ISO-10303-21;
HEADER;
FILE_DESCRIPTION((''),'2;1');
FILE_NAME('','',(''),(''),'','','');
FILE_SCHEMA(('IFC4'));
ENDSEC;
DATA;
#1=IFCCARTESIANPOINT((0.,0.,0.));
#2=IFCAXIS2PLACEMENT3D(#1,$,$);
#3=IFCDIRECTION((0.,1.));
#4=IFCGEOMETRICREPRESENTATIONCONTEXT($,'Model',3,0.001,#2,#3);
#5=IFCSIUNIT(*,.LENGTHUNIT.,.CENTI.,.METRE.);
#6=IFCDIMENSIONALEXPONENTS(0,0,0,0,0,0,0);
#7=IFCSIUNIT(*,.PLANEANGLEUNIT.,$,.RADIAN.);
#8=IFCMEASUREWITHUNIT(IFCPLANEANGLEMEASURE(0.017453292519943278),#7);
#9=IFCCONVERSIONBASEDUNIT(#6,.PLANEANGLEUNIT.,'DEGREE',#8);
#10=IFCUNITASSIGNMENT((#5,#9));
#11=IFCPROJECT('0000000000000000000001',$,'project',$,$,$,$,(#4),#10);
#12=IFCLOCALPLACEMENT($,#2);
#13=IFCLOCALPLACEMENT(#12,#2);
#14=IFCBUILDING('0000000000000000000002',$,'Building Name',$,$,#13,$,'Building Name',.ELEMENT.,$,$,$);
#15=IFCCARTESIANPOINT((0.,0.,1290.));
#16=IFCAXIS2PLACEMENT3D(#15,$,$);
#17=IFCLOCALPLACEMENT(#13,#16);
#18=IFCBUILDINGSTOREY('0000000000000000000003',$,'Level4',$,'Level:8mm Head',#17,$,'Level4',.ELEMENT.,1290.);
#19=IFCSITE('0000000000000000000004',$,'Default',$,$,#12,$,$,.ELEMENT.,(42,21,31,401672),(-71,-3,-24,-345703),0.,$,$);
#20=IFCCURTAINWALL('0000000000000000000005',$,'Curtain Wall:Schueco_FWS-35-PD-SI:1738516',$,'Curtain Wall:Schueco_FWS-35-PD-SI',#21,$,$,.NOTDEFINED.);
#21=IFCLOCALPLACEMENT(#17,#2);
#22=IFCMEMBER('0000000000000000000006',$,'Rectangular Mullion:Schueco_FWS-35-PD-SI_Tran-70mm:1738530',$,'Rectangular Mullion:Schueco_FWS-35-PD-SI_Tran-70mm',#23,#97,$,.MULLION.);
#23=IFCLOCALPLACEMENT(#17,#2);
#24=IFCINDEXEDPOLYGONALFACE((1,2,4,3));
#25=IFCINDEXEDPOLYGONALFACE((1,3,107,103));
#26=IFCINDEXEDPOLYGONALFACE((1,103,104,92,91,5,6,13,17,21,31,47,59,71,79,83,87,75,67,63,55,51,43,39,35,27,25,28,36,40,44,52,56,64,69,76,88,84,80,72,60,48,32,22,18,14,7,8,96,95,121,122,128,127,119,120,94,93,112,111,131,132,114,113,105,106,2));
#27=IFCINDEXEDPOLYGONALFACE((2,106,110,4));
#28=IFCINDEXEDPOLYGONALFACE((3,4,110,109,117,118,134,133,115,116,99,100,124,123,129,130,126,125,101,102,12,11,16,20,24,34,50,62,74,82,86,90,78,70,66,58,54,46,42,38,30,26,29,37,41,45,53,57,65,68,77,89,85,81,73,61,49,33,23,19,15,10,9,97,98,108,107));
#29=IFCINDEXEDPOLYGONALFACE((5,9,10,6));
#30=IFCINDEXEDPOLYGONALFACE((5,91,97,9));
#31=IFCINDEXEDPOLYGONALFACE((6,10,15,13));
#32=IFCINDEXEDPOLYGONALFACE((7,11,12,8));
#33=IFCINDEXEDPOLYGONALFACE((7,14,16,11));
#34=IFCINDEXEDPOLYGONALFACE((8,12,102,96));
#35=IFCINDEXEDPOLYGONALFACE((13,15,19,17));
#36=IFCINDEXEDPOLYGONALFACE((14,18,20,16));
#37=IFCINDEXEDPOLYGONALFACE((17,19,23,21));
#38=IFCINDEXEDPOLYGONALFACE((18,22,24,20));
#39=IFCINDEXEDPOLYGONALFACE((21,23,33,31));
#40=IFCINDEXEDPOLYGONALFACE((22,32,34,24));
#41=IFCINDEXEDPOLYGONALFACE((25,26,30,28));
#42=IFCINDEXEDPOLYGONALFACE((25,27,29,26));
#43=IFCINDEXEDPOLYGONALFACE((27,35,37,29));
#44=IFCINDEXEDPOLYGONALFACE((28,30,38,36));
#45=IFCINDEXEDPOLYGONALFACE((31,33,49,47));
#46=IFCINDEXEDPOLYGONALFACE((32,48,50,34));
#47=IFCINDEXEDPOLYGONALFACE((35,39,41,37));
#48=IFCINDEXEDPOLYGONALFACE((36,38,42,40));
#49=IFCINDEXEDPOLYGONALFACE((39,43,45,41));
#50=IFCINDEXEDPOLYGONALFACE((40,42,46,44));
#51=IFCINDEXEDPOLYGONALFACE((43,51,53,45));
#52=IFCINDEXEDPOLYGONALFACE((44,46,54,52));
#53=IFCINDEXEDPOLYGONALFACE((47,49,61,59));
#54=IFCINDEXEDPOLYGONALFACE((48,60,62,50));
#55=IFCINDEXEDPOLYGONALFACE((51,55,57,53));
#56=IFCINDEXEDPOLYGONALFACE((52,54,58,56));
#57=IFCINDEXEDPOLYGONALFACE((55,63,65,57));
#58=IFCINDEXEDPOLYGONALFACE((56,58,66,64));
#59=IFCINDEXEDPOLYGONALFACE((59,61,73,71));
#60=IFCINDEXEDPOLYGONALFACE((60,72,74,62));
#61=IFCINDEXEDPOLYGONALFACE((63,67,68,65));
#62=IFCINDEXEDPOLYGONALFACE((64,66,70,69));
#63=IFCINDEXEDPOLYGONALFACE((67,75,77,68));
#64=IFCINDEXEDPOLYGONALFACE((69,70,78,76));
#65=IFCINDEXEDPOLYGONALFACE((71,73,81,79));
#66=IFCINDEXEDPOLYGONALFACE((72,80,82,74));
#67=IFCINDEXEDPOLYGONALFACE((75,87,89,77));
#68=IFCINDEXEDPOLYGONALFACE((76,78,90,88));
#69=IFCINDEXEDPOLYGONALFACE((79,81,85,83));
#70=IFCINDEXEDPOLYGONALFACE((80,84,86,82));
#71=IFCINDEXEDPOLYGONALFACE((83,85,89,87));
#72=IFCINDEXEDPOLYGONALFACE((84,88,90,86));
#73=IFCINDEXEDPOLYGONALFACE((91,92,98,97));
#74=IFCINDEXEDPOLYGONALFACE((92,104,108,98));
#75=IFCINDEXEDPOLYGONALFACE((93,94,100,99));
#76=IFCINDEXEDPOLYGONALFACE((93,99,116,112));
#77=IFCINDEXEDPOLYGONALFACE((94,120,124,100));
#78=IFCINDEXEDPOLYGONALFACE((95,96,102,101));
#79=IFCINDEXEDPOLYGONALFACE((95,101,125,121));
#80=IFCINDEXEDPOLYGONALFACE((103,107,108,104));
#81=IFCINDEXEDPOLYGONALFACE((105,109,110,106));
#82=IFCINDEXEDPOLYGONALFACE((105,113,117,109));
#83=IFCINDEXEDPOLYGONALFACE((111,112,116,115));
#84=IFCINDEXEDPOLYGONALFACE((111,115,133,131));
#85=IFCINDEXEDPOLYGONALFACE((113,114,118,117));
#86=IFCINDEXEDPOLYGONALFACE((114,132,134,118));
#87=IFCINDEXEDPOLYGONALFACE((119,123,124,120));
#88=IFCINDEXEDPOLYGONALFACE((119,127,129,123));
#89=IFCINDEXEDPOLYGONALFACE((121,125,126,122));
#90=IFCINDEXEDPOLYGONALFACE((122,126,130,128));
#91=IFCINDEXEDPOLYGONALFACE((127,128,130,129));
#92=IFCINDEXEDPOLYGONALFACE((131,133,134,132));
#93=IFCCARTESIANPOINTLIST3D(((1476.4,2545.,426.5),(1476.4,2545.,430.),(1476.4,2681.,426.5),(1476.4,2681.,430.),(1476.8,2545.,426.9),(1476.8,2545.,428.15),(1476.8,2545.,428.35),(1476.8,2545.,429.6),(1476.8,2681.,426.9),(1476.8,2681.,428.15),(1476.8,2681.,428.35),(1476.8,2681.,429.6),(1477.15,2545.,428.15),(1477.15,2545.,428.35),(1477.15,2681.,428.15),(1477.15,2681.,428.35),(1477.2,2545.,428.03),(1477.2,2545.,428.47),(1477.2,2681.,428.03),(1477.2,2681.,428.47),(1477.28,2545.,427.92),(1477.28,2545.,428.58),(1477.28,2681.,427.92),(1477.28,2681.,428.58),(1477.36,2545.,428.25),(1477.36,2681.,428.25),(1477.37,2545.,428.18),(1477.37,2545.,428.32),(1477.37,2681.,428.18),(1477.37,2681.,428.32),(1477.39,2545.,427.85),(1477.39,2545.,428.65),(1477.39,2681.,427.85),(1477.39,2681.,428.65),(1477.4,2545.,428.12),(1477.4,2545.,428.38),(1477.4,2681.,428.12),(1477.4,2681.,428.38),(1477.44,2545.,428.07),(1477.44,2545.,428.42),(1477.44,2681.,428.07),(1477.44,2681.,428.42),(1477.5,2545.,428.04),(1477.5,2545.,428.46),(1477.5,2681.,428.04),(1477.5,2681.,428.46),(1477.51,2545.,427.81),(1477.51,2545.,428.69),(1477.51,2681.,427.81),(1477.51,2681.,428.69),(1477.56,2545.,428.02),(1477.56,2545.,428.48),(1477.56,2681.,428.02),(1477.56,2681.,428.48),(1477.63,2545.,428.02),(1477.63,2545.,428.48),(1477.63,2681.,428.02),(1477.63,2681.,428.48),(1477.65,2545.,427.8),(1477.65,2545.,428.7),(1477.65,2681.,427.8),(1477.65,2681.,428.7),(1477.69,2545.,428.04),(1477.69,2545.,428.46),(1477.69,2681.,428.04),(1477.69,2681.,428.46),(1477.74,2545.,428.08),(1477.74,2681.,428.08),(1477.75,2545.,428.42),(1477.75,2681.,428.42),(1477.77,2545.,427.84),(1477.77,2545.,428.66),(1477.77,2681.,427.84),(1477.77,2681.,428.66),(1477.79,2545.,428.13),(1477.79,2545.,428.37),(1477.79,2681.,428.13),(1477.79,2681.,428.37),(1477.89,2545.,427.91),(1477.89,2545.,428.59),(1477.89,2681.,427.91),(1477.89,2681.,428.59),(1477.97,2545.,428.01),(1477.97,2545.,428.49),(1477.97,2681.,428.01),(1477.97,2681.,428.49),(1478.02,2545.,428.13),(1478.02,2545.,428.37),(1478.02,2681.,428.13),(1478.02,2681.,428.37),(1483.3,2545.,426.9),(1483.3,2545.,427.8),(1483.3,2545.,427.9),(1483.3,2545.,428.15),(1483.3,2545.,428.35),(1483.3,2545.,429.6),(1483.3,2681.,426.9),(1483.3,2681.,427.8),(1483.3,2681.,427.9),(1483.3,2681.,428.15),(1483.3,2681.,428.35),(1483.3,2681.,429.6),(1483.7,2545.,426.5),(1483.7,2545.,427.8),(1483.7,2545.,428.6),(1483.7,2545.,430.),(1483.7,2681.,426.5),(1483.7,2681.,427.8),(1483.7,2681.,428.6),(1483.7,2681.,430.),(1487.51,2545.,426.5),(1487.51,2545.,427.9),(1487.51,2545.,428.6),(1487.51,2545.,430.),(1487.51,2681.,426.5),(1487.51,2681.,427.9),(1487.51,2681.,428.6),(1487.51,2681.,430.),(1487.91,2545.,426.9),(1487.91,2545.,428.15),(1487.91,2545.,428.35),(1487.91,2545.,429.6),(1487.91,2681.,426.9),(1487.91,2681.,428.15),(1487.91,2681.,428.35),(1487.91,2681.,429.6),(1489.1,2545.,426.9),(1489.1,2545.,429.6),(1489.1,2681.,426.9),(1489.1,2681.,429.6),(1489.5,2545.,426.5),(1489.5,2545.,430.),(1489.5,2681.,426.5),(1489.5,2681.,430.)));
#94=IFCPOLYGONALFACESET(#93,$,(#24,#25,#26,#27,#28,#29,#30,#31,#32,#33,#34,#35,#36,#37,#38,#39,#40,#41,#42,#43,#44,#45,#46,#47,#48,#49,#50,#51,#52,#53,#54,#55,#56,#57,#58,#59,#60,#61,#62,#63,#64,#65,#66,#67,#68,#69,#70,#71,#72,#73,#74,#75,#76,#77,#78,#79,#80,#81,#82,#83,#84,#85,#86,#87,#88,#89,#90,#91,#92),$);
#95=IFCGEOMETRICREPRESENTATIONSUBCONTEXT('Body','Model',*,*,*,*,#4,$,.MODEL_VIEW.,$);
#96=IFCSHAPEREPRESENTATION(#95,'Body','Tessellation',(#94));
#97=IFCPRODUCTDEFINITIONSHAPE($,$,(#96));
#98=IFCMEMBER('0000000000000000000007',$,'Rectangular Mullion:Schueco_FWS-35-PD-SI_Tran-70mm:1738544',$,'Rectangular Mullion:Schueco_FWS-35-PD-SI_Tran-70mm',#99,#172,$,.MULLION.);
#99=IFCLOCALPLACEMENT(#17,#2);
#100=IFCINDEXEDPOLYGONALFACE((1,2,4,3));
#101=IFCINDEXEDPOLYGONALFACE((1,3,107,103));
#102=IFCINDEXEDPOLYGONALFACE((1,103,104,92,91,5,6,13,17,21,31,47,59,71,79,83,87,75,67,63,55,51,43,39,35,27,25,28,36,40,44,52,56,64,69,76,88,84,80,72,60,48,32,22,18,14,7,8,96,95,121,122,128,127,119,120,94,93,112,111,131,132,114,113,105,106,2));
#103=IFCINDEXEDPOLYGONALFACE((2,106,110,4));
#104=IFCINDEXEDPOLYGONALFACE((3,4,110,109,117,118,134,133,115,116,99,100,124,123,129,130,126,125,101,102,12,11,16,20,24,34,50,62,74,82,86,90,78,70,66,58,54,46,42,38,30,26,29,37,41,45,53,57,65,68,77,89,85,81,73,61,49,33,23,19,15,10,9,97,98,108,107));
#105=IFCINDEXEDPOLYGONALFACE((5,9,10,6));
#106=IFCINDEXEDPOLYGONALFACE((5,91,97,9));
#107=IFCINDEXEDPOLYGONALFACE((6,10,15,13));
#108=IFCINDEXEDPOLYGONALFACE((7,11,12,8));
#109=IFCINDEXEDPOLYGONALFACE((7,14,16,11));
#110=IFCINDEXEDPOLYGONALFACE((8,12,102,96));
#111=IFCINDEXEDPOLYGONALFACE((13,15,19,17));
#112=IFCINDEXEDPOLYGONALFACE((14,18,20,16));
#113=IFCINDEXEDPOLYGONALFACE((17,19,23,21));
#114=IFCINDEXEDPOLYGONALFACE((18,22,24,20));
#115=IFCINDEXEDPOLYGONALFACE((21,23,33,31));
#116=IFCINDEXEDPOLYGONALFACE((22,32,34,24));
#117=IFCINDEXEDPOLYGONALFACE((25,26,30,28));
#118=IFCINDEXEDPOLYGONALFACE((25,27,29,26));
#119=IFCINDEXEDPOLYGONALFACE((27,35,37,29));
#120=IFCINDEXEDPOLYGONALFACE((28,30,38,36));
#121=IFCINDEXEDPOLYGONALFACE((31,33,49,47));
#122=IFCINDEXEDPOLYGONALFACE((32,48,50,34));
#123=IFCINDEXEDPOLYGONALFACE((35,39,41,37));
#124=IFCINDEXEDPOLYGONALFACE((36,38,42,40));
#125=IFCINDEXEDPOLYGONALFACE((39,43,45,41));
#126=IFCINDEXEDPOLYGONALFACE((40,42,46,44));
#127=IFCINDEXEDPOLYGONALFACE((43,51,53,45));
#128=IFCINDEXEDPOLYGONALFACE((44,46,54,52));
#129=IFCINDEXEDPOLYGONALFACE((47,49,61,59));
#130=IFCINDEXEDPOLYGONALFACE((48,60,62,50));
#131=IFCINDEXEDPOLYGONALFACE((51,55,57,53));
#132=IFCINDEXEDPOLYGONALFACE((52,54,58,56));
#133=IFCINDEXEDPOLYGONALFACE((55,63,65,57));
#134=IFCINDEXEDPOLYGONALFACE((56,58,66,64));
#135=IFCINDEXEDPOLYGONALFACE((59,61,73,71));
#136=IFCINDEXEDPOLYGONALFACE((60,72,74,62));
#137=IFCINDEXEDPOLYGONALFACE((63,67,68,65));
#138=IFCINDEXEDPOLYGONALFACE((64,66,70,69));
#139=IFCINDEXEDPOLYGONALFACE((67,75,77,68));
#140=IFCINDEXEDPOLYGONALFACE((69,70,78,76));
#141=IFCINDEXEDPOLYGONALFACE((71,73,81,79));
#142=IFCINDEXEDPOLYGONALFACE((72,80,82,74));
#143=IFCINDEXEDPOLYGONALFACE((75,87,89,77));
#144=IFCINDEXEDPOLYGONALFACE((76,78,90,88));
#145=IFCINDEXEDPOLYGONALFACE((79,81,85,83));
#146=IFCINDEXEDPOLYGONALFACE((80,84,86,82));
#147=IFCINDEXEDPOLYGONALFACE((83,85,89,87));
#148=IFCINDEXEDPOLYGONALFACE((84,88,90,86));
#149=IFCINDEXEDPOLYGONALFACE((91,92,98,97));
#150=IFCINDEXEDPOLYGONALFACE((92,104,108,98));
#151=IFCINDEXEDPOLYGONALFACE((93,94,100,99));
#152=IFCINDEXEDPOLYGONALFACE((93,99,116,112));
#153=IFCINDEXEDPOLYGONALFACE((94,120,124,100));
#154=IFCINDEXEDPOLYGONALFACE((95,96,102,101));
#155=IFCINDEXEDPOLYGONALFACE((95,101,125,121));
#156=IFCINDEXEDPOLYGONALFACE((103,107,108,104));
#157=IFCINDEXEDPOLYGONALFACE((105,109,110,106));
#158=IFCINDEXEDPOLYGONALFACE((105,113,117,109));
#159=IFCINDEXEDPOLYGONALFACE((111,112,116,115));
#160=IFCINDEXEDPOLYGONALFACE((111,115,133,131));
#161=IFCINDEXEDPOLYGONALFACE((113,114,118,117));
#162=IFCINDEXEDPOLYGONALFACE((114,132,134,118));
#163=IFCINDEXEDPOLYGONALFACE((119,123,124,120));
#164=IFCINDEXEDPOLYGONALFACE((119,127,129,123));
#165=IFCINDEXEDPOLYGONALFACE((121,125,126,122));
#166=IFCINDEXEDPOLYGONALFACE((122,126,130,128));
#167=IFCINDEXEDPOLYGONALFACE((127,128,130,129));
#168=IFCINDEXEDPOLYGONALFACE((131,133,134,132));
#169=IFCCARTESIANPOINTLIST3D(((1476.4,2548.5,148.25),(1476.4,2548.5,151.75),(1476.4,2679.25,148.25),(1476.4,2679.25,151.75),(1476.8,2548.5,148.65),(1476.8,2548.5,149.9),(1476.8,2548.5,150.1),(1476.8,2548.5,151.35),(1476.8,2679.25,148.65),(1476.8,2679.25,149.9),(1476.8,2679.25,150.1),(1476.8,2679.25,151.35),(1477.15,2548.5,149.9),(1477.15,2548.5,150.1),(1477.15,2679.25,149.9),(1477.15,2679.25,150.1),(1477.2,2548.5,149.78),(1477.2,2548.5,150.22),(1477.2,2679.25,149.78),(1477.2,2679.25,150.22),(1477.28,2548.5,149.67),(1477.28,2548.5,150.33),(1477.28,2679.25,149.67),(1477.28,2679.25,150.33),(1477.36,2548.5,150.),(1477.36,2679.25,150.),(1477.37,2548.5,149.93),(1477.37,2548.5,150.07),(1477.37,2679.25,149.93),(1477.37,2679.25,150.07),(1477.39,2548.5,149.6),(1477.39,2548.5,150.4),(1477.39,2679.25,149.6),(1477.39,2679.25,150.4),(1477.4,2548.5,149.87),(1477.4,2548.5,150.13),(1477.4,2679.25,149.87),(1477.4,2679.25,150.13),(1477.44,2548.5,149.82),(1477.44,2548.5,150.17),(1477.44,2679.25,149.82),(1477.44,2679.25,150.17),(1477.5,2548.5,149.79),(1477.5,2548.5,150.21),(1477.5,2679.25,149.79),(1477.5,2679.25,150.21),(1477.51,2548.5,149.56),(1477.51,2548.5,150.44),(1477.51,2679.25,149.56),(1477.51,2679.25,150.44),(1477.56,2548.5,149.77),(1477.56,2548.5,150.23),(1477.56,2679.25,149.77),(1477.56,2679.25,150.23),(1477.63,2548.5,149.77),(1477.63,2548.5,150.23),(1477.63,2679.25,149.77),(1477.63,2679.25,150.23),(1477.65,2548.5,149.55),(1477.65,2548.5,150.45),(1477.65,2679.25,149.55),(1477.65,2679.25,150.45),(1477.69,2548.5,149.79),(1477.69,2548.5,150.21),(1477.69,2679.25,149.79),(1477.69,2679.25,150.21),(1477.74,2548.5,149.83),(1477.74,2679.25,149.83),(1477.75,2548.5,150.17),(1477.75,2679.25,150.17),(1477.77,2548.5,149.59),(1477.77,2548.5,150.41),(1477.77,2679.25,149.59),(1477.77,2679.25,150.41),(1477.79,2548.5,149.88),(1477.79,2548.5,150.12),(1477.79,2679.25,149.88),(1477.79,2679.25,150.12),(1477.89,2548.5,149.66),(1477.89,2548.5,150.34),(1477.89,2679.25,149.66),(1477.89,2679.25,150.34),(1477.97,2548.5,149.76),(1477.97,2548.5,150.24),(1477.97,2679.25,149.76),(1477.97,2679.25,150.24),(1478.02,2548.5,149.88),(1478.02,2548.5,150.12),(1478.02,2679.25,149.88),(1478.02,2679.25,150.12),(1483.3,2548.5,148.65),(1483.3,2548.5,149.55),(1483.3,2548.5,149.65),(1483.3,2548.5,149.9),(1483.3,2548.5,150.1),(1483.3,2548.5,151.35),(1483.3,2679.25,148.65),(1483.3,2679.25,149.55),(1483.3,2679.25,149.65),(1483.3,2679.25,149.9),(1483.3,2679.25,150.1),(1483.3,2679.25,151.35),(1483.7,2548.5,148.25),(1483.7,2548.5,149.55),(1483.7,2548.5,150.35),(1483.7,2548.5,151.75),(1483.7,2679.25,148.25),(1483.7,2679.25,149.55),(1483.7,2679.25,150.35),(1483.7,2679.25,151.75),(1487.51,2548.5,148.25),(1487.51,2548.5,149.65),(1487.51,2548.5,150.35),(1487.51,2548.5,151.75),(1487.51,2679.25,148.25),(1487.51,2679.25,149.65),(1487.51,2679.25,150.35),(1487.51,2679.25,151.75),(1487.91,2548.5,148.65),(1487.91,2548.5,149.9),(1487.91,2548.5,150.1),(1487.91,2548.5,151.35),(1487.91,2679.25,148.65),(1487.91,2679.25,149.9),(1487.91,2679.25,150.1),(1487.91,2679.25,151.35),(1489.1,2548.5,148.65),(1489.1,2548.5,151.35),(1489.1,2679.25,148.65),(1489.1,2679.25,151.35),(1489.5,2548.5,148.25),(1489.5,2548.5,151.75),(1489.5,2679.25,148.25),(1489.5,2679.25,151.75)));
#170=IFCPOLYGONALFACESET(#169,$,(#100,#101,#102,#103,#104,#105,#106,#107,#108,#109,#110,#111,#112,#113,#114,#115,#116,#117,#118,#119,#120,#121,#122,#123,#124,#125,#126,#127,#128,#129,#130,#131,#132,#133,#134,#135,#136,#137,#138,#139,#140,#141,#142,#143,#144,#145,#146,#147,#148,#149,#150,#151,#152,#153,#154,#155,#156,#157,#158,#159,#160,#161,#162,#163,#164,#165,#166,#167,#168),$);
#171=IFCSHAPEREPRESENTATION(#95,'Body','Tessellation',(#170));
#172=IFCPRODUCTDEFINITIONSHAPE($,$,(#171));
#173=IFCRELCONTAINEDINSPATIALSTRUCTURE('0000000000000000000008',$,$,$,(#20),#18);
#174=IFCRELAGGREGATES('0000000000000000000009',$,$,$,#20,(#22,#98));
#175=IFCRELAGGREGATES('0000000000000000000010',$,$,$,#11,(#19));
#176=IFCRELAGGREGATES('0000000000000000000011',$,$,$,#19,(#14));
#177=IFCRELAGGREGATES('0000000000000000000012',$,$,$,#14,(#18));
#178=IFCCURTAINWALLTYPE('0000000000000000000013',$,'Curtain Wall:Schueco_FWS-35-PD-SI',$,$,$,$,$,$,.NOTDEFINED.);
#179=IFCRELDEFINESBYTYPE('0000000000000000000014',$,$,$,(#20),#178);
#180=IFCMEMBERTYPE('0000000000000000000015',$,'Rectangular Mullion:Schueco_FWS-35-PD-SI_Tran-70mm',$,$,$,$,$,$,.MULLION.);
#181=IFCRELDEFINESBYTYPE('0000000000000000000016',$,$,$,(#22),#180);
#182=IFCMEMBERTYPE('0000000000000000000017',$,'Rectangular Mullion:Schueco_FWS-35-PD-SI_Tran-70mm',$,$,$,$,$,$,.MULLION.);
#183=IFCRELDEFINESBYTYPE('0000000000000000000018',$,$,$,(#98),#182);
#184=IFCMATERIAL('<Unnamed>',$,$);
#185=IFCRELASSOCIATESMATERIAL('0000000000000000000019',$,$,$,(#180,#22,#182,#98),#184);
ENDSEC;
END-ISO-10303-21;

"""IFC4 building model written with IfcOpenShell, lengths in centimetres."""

from ifc_helpers import new_model, entity, si_unit, converted_unit, direction, frame, origin, place, context, subcontext, project, spatial, line, arc, indexed_curve, outline, extrude, source, transform, mapped, material, type_object, type_shapes, element, aggregate, save


model = new_model("IFC4")

# Units and contexts
model_context = context("Model", 3, precision=0.001, world=origin(), true_north=direction((0.0, 1.0)))
body_context = subcontext(model_context, "Body", "Model", "MODEL_VIEW")
ifc_project = project(units=[si_unit("LENGTHUNIT", "METRE", prefix="CENTI"), converted_unit("PLANEANGLEUNIT", "DEGREE", entity("IfcPlaneAngleMeasure", 0.017453292519943278), si_unit("PLANEANGLEUNIT", "RADIAN"), dimensions=[0, 0, 0, 0, 0, 0, 0])], contexts=[model_context])

# Site, building, storey
site_placement = place(None, origin())
site = spatial("IfcSite", under=ifc_project, at=site_placement, Name="Default", CompositionType="ELEMENT", RefLatitude=(42, 21, 31, 401672), RefLongitude=(-71, -3, -24, -345703), RefElevation=0.0)
building_placement = place(site_placement, origin())
building = spatial("IfcBuilding", under=site, at=building_placement, Name="Building Name", LongName="Building Name", CompositionType="ELEMENT")
storey_placement = place(building_placement, frame((0.0, 0.0, 1290.0)))
storey = spatial("IfcBuildingStorey", under=building, at=storey_placement, Name="Level4", ObjectType="Level:8mm Head", LongName="Level4", CompositionType="ELEMENT", Elevation=1290.0)

# Curtain wall, members
curtain_wall_type = type_object("IfcCurtainWallType", Name="Curtain Wall:Schueco_FWS-35-PD-SI", PredefinedType="NOTDEFINED")
curtain_wall_placement = place(storey_placement, frame((0.0, 0.0, -1290.0)))
curtain_wall = element("IfcCurtainWall", 1, at=curtain_wall_placement, inside=storey, type_object=curtain_wall_type, Name="Curtain Wall:Schueco_FWS-35-PD-SI:1738516", ObjectType="Curtain Wall:Schueco_FWS-35-PD-SI", PredefinedType="NOTDEFINED")
ifc_material_1 = material(Name="<Unnamed>")
member_type_1 = type_object("IfcMemberType", Name="Rectangular Mullion:Schueco_FWS-35-PD-SI_Tran-70mm", PredefinedType="MULLION", material=ifc_material_1)
shared_shape_1 = source(origin(), body_context, "Body", "SweptSolid", [
    extrude(outline(indexed_curve([(-1.78, -6.52), (1.72, -6.52), (1.72, 0.78), (0.42, 0.78), (0.42, 0.38), (1.32, 0.38), (1.32, -6.12), (0.07, -6.12), (0.07, -5.77), (0.42, -5.34), (0.09, -4.9), (0.09, -5.14), (-0.03, -5.56), (-0.15, -5.14), (-0.15, -4.9), (-0.48, -5.34), (-0.13, -5.77), (-0.13, -6.12), (-1.38, -6.12), (-1.38, 0.38), (-0.13, 0.38), (-0.13, 4.99), (-1.38, 4.99), (-1.38, 6.18), (1.32, 6.18), (1.32, 4.99), (0.07, 4.99), (0.07, 0.38), (0.32, 0.38), (0.32, 4.59), (1.72, 4.59), (1.72, 6.58), (-1.78, 6.58), (-1.78, 4.59), (-0.38, 4.59), (-0.38, 0.78), (-1.78, 0.78)], segments=[line(1, 2, 3, 4, 5, 6, 7, 8, 9), arc(9, 10, 11), line(11, 12), arc(12, 13, 14), line(14, 15), arc(15, 16, 17), line(17, 18, 19, 20, 21, 22, 23, 24, 25, 26, 27, 28, 29, 30, 31, 32, 33, 34, 35, 36, 37, 1)], self_intersect=False)), frame((-1.78, 4.58, -136.0), z_axis=(0.0, 0.0, 1.0), x_axis=(-1.0, 0.0, 0.0)), (0.0, 0.0, 1.0), 136.0),
])
type_shapes(member_type_1, [shared_shape_1])
member_1_placement = place(curtain_wall_placement, frame((1487.5, 2545.0, 1720.0), z_axis=(0.0, -1.0, 0.0), x_axis=(0.0, 0.0, 1.0)))
member_1 = element("IfcMember", 2, at=member_1_placement, type_object=member_type_1, material=ifc_material_1, Name="Rectangular Mullion:Schueco_FWS-35-PD-SI_Tran-70mm:1738530", ObjectType="Rectangular Mullion:Schueco_FWS-35-PD-SI_Tran-70mm", PredefinedType="MULLION", context=body_context, shape_type="MappedRepresentation", body=[
    mapped(shared_shape_1, transform((0.0, 0.0, 0.0), scale=1.0)),
])
member_type_2 = type_object("IfcMemberType", Name="Rectangular Mullion:Schueco_FWS-35-PD-SI_Tran-70mm", PredefinedType="MULLION", material=ifc_material_1)
shared_shape_2 = source(origin(), body_context, "Body", "SweptSolid", [
    extrude(outline(indexed_curve([(-1.78, -6.52), (1.72, -6.52), (1.72, 0.78), (0.42, 0.78), (0.42, 0.38), (1.32, 0.38), (1.32, -6.12), (0.07, -6.12), (0.07, -5.77), (0.42, -5.34), (0.09, -4.9), (0.09, -5.14), (-0.03, -5.56), (-0.15, -5.14), (-0.15, -4.9), (-0.48, -5.34), (-0.13, -5.77), (-0.13, -6.12), (-1.38, -6.12), (-1.38, 0.38), (-0.13, 0.38), (-0.13, 4.99), (-1.38, 4.99), (-1.38, 6.18), (1.32, 6.18), (1.32, 4.99), (0.07, 4.99), (0.07, 0.38), (0.32, 0.38), (0.32, 4.59), (1.72, 4.59), (1.72, 6.58), (-1.78, 6.58), (-1.78, 4.59), (-0.38, 4.59), (-0.38, 0.78), (-1.78, 0.78)], segments=[line(1, 2, 3, 4, 5, 6, 7, 8, 9), arc(9, 10, 11), line(11, 12), arc(12, 13, 14), line(14, 15), arc(15, 16, 17), line(17, 18, 19, 20, 21, 22, 23, 24, 25, 26, 27, 28, 29, 30, 31, 32, 33, 34, 35, 36, 37, 1)], self_intersect=False)), frame((-0.03, 4.58, -130.75), z_axis=(0.0, 0.0, 1.0), x_axis=(-1.0, 0.0, 0.0)), (0.0, 0.0, 1.0), 130.75),
])
type_shapes(member_type_2, [shared_shape_2])
member_2_placement = place(curtain_wall_placement, frame((1487.5, 2548.5, 1440.0), z_axis=(0.0, -1.0, 0.0), x_axis=(0.0, 0.0, 1.0)))
member_2 = element("IfcMember", 3, at=member_2_placement, type_object=member_type_2, material=ifc_material_1, Name="Rectangular Mullion:Schueco_FWS-35-PD-SI_Tran-70mm:1738544", ObjectType="Rectangular Mullion:Schueco_FWS-35-PD-SI_Tran-70mm", PredefinedType="MULLION", context=body_context, shape_type="MappedRepresentation", body=[
    mapped(shared_shape_2, transform((0.0, 0.0, 0.0), scale=1.0)),
])
aggregate(curtain_wall, [member_1, member_2])

save(model, "model.ifc")
